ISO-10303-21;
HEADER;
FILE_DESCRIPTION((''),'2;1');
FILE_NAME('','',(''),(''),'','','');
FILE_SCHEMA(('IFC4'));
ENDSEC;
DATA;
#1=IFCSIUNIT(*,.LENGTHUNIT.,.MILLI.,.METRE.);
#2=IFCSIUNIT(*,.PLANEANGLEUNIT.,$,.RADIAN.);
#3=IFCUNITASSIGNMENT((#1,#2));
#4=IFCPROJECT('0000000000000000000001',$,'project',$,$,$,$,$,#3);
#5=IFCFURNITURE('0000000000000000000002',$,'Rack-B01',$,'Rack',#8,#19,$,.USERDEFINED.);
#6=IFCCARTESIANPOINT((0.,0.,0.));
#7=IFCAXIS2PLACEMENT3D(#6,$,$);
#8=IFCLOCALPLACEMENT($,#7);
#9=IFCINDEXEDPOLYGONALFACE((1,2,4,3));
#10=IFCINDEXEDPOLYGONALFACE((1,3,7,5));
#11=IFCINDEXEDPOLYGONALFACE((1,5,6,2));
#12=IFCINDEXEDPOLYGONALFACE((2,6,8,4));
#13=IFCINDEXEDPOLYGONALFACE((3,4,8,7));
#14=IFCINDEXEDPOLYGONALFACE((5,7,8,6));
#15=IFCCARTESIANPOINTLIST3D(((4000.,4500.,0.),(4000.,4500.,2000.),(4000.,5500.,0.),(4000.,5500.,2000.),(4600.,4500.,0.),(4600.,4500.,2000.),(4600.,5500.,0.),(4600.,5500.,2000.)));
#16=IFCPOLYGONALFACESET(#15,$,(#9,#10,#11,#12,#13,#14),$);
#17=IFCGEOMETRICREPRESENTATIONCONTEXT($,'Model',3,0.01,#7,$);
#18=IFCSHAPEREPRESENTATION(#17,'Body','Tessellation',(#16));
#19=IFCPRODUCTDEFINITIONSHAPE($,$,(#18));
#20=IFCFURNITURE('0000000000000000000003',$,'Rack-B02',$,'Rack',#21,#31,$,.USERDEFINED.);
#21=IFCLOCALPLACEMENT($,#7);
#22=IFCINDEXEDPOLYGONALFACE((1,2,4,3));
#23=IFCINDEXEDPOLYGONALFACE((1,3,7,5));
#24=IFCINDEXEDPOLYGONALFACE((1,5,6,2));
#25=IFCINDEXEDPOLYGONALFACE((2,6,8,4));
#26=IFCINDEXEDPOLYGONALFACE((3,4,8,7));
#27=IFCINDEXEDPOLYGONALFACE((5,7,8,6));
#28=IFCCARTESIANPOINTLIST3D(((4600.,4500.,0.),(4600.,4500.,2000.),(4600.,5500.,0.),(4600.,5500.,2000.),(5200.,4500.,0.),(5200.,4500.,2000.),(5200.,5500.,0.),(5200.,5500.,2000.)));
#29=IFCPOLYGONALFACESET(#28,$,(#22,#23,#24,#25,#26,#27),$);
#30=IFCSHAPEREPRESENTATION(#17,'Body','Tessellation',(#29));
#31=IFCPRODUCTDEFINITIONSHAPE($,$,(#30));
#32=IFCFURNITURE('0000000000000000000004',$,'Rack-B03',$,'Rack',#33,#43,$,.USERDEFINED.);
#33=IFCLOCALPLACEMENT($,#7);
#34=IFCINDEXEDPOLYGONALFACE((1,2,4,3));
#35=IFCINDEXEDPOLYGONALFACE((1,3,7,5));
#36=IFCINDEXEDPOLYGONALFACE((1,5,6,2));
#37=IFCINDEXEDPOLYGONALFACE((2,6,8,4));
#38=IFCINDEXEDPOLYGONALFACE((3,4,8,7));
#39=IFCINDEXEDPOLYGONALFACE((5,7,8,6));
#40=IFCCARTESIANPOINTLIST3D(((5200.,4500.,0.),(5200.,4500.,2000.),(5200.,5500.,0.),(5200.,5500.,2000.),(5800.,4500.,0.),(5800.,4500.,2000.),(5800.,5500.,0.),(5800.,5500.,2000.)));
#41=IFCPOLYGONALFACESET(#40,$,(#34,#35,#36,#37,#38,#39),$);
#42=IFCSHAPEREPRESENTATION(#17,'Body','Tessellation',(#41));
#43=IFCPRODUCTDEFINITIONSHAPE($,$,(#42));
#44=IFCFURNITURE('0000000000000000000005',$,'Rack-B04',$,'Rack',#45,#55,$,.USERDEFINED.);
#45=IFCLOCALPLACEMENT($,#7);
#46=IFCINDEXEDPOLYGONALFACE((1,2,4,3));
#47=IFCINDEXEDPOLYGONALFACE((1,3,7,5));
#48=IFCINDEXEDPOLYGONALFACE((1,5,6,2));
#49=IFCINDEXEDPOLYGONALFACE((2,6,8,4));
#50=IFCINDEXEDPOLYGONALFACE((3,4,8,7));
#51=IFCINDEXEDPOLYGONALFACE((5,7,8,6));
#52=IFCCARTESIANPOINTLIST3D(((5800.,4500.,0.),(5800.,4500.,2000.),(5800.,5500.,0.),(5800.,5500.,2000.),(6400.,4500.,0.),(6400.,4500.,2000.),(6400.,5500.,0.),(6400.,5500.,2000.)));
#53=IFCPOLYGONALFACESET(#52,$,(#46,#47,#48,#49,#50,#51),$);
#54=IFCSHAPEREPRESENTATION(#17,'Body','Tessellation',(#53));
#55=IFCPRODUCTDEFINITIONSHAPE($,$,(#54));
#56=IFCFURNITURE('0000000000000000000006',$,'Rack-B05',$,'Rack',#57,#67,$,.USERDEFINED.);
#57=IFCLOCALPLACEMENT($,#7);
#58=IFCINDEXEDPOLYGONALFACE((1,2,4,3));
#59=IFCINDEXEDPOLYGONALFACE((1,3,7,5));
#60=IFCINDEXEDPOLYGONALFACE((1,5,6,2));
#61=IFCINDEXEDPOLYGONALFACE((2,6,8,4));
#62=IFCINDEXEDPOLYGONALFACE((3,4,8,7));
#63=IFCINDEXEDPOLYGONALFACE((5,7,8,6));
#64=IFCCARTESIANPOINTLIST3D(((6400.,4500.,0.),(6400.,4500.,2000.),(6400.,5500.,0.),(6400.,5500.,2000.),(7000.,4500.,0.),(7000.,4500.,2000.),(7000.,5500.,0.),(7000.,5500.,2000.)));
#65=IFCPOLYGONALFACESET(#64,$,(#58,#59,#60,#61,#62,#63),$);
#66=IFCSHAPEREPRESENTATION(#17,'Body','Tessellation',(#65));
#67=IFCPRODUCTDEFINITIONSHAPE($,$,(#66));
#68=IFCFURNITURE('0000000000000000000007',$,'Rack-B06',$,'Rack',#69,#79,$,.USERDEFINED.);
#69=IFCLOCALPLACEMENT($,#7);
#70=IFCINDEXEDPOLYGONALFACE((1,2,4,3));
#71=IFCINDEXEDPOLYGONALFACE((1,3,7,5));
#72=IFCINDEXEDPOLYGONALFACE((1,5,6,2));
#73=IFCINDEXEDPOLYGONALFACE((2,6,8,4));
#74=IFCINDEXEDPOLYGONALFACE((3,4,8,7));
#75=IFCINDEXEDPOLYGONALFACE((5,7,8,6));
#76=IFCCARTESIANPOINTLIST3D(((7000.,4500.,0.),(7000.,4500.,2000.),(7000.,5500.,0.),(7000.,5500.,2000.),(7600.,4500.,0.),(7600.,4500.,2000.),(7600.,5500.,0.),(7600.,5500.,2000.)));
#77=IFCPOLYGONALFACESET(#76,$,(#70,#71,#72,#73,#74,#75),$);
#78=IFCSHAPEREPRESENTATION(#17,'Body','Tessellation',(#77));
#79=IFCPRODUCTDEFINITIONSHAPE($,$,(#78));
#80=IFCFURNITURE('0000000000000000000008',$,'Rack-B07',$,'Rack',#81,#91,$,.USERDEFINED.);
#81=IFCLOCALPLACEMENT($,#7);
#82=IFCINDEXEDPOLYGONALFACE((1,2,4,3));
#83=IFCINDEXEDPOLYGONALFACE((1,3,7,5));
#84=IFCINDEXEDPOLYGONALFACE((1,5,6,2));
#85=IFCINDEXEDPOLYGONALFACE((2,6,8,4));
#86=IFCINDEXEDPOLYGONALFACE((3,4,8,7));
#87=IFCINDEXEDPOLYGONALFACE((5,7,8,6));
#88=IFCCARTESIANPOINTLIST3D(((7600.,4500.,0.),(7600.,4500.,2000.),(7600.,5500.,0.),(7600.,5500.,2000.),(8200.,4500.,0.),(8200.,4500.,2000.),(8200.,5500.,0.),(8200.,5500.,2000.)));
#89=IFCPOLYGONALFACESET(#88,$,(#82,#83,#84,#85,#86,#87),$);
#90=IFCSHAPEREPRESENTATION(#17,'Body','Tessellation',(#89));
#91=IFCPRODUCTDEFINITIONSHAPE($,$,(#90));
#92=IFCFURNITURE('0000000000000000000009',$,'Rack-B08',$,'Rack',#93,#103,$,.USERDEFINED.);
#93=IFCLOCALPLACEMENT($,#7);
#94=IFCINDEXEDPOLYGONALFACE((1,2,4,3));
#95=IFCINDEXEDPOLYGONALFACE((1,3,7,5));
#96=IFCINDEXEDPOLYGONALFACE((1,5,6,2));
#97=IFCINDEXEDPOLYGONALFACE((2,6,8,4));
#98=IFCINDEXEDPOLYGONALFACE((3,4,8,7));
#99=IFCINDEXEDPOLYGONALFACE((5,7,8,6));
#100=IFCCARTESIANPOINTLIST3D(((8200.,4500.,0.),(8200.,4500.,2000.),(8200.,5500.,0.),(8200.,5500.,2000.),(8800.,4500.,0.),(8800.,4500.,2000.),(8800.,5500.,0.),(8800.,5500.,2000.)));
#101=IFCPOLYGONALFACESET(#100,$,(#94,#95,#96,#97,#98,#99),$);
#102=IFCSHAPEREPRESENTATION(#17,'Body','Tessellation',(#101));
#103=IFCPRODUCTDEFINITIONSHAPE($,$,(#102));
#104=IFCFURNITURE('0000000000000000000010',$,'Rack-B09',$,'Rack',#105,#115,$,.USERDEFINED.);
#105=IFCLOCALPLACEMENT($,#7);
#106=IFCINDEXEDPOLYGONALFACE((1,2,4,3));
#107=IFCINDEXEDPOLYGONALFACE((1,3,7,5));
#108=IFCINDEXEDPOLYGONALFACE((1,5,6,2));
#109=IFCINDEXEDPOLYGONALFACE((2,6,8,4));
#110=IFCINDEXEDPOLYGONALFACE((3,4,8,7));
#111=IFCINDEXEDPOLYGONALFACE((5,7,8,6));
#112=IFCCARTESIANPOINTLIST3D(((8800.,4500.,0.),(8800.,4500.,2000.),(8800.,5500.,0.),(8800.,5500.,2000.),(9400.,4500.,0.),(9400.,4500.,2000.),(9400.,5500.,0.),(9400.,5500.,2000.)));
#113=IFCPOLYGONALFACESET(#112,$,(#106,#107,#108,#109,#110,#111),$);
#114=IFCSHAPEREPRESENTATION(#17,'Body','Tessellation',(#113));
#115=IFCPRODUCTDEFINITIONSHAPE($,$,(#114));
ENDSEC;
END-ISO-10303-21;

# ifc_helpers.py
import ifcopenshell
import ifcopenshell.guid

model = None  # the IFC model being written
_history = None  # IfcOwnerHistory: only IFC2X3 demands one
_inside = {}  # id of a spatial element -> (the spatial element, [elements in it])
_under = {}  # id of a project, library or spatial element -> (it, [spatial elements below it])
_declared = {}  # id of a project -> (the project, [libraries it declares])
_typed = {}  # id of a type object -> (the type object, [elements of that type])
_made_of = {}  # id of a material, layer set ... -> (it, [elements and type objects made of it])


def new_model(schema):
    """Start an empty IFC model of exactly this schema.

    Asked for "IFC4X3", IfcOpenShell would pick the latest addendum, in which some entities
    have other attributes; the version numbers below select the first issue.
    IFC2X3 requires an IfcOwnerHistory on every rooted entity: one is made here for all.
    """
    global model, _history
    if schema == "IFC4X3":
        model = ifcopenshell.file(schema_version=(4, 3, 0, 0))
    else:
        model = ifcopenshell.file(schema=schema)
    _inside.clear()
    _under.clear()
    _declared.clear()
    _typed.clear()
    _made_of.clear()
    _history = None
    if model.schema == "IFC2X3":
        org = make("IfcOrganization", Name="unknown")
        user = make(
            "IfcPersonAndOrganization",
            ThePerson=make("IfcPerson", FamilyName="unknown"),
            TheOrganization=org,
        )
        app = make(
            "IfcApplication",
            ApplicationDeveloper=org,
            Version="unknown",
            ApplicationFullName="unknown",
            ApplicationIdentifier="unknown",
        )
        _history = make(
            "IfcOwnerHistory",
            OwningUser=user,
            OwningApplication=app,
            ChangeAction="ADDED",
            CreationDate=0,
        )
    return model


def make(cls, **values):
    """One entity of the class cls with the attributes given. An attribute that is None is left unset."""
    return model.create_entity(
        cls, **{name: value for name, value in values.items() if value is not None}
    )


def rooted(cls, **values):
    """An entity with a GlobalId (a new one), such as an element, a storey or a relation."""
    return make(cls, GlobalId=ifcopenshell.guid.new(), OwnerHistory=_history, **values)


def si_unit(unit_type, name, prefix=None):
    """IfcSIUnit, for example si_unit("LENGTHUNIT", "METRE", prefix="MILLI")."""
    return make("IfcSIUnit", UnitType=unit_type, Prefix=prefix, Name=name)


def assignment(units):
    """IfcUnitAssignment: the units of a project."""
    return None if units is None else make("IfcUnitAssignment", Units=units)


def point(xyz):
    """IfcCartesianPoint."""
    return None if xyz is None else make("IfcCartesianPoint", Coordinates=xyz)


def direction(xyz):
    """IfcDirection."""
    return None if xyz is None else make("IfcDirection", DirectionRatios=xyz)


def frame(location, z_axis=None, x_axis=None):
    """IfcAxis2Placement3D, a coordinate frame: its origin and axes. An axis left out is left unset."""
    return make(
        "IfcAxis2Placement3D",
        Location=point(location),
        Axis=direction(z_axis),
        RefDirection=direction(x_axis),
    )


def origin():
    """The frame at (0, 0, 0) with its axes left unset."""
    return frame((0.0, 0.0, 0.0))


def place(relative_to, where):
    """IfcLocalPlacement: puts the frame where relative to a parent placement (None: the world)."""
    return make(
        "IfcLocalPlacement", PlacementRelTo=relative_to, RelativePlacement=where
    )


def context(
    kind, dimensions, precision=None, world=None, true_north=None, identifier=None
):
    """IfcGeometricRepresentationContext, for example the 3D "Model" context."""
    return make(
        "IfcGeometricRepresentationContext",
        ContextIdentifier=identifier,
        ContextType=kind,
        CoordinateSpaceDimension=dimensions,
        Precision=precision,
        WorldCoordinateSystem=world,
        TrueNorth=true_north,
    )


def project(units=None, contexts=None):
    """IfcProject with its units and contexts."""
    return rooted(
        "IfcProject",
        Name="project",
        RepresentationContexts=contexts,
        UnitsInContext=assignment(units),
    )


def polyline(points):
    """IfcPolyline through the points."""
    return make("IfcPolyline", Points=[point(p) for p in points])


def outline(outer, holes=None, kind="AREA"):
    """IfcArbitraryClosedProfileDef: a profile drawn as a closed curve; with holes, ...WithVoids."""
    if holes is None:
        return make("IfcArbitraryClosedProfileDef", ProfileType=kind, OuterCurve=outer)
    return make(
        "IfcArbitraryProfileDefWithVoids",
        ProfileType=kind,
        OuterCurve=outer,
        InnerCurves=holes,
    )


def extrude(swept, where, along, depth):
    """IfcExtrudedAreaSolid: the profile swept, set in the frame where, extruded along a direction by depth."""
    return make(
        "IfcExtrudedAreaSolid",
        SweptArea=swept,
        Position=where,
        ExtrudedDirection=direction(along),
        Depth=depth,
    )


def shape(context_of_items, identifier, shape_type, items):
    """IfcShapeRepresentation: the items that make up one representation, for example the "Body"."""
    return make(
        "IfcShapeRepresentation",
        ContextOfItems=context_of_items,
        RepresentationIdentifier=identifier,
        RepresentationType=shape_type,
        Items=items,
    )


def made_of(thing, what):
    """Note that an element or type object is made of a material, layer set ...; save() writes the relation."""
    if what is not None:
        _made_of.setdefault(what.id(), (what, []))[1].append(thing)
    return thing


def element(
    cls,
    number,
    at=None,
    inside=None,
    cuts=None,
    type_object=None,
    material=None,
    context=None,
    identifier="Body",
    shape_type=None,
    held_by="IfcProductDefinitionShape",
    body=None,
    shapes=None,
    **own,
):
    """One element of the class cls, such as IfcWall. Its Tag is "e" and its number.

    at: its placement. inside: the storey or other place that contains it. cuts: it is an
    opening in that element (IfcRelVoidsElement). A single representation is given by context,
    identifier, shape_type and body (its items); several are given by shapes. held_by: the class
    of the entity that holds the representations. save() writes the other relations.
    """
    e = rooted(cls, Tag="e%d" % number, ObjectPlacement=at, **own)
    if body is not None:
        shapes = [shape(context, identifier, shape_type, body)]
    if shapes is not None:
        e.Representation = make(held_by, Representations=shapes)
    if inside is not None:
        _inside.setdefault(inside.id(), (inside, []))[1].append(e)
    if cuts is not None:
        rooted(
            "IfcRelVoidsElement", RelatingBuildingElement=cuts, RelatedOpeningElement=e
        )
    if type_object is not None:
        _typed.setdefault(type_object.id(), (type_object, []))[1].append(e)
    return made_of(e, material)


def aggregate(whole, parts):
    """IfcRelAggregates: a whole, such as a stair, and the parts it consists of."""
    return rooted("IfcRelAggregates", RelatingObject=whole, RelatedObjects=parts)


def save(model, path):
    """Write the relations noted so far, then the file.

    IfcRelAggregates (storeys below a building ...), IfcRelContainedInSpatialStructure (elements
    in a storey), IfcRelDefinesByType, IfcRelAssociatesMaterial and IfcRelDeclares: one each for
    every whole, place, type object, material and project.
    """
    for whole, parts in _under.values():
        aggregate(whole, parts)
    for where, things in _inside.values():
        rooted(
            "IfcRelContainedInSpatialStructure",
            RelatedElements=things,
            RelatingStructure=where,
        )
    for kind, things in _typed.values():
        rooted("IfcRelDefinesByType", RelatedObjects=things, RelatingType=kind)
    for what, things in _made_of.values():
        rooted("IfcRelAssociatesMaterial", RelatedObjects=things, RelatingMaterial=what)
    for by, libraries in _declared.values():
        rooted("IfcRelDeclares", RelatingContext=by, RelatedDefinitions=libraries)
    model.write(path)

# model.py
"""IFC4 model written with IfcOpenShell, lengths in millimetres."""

from ifc_helpers import new_model, si_unit, frame, origin, place, context, project, polyline, outline, extrude, element, save


model = new_model("IFC4")

# Units and contexts
model_context = context("Model", 3, precision=0.01, world=origin())
ifc_project = project(units=[si_unit("LENGTHUNIT", "METRE", prefix="MILLI"), si_unit("PLANEANGLEUNIT", "RADIAN")])

# Furniture
for number, where, name in (
    (1, (4300.0, 5000.0, 0.0), "Rack-B01"),
    (2, (4900.0, 5000.0, 0.0), "Rack-B02"),
    (3, (5500.0, 5000.0, 0.0), "Rack-B03"),
    (4, (6100.0, 5000.0, 0.0), "Rack-B04"),
    (5, (6700.0, 5000.0, 0.0), "Rack-B05"),
    (6, (7300.0, 5000.0, 0.0), "Rack-B06"),
    (7, (7900.0, 5000.0, 0.0), "Rack-B07"),
    (8, (8500.0, 5000.0, 0.0), "Rack-B08"),
    (9, (9100.0, 5000.0, 0.0), "Rack-B09"),
):
    element("IfcFurniture", number, at=place(None, frame(where)), Name=name, ObjectType="Rack", PredefinedType="USERDEFINED", context=model_context, shape_type="SweptSolid", body=[
        extrude(outline(polyline([(-300.0, -500.0), (300.0, -500.0), (300.0, 500.0), (-300.0, 500.0), (-300.0, -500.0)])), origin(), (0.0, 0.0, 1.0), 2000.0),
    ])

save(model, "model.ifc")
